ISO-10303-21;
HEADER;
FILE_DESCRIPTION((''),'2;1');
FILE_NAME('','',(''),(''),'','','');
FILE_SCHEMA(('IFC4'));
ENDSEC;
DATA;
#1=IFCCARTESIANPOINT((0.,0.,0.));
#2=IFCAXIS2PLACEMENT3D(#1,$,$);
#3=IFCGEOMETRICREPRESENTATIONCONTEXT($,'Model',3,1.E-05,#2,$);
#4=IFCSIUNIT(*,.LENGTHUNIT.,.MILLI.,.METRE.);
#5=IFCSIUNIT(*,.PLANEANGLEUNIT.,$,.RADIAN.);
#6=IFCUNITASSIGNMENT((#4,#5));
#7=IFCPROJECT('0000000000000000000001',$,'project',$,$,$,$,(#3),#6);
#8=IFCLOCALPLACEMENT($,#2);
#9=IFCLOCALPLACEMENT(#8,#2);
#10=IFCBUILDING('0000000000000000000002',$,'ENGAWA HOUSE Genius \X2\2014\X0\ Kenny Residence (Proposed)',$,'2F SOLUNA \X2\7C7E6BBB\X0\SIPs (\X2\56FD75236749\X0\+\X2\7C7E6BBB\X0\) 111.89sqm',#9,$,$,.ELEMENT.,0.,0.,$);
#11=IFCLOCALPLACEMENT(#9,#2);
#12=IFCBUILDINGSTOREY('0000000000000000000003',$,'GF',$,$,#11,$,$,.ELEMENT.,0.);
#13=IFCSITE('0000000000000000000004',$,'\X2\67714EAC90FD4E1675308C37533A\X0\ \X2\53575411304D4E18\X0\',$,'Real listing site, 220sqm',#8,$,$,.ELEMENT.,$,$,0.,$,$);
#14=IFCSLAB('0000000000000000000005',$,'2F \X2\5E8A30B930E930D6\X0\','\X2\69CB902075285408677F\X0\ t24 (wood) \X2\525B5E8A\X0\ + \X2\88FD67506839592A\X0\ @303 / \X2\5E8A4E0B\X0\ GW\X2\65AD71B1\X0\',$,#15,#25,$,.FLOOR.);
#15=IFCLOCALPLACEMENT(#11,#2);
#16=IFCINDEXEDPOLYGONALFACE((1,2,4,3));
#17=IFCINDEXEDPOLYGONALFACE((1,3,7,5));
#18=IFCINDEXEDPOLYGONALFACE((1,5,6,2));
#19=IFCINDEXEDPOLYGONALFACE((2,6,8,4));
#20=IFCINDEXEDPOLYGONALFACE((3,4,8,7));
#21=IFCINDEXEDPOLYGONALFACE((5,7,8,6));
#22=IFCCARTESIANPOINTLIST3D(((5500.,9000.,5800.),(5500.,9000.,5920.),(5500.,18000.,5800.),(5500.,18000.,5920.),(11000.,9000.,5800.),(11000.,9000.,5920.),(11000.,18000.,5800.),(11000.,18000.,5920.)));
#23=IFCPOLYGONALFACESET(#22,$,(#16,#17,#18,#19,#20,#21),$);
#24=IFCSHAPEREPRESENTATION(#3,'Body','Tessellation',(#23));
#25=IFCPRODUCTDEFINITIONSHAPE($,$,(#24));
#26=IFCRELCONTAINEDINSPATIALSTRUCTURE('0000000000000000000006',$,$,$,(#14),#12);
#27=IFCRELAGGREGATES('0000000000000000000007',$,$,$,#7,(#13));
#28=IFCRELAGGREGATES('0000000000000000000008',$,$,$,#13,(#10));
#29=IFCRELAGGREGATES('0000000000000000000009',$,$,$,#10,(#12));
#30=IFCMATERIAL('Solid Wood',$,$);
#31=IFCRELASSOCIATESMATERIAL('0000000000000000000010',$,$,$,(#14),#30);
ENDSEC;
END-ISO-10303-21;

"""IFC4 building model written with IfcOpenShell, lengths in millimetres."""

from ifc_helpers import new_model, si_unit, frame, frame_2d, origin, place, context, project, spatial, rectangle, extrude, material, element, save


model = new_model("IFC4")

# Units and contexts
model_context = context("Model", 3, precision=1e-05, world=origin())
ifc_project = project(units=[si_unit("LENGTHUNIT", "METRE", prefix="MILLI"), si_unit("PLANEANGLEUNIT", "RADIAN")], contexts=[model_context])

# Site, building, storey
site_placement = place(None, origin())
site = spatial("IfcSite", under=ifc_project, at=site_placement, Name="東京都世田谷区 南向き丘", ObjectType="Real listing site, 220sqm", CompositionType="ELEMENT", RefElevation=0.0)
building_placement = place(site_placement, origin())
building = spatial("IfcBuilding", under=site, at=building_placement, Name="ENGAWA HOUSE Genius — Kenny Residence (Proposed)", ObjectType="2F SOLUNA 籾殻SIPs (国産杉+籾殻) 111.89sqm", CompositionType="ELEMENT", ElevationOfRefHeight=0.0, ElevationOfTerrain=0.0)
storey_placement = place(building_placement, origin())
storey = spatial("IfcBuildingStorey", under=building, at=storey_placement, Name="GF", CompositionType="ELEMENT", Elevation=0.0)

# Slab
ifc_material_1 = material(Name="Solid Wood")
slab_placement = place(storey_placement, frame((2750.0, 4500.0, 2900.0)))
element("IfcSlab", 1, at=slab_placement, inside=storey, material=ifc_material_1, Name="2F 床スラブ", Description="構造用合板 t24 (wood) 剛床 + 製材根太 @303 / 床下 GW断熱", PredefinedType="FLOOR", context=model_context, shape_type="SweptSolid", body=[
    extrude(rectangle(XDim=5500.0, YDim=9000.0, at=frame_2d((2750.0, 4500.0))), frame((2750.0, 4500.0, 2900.0)), (0.0, 0.0, 1.0), 120.0),
])

save(model, "model.ifc")
